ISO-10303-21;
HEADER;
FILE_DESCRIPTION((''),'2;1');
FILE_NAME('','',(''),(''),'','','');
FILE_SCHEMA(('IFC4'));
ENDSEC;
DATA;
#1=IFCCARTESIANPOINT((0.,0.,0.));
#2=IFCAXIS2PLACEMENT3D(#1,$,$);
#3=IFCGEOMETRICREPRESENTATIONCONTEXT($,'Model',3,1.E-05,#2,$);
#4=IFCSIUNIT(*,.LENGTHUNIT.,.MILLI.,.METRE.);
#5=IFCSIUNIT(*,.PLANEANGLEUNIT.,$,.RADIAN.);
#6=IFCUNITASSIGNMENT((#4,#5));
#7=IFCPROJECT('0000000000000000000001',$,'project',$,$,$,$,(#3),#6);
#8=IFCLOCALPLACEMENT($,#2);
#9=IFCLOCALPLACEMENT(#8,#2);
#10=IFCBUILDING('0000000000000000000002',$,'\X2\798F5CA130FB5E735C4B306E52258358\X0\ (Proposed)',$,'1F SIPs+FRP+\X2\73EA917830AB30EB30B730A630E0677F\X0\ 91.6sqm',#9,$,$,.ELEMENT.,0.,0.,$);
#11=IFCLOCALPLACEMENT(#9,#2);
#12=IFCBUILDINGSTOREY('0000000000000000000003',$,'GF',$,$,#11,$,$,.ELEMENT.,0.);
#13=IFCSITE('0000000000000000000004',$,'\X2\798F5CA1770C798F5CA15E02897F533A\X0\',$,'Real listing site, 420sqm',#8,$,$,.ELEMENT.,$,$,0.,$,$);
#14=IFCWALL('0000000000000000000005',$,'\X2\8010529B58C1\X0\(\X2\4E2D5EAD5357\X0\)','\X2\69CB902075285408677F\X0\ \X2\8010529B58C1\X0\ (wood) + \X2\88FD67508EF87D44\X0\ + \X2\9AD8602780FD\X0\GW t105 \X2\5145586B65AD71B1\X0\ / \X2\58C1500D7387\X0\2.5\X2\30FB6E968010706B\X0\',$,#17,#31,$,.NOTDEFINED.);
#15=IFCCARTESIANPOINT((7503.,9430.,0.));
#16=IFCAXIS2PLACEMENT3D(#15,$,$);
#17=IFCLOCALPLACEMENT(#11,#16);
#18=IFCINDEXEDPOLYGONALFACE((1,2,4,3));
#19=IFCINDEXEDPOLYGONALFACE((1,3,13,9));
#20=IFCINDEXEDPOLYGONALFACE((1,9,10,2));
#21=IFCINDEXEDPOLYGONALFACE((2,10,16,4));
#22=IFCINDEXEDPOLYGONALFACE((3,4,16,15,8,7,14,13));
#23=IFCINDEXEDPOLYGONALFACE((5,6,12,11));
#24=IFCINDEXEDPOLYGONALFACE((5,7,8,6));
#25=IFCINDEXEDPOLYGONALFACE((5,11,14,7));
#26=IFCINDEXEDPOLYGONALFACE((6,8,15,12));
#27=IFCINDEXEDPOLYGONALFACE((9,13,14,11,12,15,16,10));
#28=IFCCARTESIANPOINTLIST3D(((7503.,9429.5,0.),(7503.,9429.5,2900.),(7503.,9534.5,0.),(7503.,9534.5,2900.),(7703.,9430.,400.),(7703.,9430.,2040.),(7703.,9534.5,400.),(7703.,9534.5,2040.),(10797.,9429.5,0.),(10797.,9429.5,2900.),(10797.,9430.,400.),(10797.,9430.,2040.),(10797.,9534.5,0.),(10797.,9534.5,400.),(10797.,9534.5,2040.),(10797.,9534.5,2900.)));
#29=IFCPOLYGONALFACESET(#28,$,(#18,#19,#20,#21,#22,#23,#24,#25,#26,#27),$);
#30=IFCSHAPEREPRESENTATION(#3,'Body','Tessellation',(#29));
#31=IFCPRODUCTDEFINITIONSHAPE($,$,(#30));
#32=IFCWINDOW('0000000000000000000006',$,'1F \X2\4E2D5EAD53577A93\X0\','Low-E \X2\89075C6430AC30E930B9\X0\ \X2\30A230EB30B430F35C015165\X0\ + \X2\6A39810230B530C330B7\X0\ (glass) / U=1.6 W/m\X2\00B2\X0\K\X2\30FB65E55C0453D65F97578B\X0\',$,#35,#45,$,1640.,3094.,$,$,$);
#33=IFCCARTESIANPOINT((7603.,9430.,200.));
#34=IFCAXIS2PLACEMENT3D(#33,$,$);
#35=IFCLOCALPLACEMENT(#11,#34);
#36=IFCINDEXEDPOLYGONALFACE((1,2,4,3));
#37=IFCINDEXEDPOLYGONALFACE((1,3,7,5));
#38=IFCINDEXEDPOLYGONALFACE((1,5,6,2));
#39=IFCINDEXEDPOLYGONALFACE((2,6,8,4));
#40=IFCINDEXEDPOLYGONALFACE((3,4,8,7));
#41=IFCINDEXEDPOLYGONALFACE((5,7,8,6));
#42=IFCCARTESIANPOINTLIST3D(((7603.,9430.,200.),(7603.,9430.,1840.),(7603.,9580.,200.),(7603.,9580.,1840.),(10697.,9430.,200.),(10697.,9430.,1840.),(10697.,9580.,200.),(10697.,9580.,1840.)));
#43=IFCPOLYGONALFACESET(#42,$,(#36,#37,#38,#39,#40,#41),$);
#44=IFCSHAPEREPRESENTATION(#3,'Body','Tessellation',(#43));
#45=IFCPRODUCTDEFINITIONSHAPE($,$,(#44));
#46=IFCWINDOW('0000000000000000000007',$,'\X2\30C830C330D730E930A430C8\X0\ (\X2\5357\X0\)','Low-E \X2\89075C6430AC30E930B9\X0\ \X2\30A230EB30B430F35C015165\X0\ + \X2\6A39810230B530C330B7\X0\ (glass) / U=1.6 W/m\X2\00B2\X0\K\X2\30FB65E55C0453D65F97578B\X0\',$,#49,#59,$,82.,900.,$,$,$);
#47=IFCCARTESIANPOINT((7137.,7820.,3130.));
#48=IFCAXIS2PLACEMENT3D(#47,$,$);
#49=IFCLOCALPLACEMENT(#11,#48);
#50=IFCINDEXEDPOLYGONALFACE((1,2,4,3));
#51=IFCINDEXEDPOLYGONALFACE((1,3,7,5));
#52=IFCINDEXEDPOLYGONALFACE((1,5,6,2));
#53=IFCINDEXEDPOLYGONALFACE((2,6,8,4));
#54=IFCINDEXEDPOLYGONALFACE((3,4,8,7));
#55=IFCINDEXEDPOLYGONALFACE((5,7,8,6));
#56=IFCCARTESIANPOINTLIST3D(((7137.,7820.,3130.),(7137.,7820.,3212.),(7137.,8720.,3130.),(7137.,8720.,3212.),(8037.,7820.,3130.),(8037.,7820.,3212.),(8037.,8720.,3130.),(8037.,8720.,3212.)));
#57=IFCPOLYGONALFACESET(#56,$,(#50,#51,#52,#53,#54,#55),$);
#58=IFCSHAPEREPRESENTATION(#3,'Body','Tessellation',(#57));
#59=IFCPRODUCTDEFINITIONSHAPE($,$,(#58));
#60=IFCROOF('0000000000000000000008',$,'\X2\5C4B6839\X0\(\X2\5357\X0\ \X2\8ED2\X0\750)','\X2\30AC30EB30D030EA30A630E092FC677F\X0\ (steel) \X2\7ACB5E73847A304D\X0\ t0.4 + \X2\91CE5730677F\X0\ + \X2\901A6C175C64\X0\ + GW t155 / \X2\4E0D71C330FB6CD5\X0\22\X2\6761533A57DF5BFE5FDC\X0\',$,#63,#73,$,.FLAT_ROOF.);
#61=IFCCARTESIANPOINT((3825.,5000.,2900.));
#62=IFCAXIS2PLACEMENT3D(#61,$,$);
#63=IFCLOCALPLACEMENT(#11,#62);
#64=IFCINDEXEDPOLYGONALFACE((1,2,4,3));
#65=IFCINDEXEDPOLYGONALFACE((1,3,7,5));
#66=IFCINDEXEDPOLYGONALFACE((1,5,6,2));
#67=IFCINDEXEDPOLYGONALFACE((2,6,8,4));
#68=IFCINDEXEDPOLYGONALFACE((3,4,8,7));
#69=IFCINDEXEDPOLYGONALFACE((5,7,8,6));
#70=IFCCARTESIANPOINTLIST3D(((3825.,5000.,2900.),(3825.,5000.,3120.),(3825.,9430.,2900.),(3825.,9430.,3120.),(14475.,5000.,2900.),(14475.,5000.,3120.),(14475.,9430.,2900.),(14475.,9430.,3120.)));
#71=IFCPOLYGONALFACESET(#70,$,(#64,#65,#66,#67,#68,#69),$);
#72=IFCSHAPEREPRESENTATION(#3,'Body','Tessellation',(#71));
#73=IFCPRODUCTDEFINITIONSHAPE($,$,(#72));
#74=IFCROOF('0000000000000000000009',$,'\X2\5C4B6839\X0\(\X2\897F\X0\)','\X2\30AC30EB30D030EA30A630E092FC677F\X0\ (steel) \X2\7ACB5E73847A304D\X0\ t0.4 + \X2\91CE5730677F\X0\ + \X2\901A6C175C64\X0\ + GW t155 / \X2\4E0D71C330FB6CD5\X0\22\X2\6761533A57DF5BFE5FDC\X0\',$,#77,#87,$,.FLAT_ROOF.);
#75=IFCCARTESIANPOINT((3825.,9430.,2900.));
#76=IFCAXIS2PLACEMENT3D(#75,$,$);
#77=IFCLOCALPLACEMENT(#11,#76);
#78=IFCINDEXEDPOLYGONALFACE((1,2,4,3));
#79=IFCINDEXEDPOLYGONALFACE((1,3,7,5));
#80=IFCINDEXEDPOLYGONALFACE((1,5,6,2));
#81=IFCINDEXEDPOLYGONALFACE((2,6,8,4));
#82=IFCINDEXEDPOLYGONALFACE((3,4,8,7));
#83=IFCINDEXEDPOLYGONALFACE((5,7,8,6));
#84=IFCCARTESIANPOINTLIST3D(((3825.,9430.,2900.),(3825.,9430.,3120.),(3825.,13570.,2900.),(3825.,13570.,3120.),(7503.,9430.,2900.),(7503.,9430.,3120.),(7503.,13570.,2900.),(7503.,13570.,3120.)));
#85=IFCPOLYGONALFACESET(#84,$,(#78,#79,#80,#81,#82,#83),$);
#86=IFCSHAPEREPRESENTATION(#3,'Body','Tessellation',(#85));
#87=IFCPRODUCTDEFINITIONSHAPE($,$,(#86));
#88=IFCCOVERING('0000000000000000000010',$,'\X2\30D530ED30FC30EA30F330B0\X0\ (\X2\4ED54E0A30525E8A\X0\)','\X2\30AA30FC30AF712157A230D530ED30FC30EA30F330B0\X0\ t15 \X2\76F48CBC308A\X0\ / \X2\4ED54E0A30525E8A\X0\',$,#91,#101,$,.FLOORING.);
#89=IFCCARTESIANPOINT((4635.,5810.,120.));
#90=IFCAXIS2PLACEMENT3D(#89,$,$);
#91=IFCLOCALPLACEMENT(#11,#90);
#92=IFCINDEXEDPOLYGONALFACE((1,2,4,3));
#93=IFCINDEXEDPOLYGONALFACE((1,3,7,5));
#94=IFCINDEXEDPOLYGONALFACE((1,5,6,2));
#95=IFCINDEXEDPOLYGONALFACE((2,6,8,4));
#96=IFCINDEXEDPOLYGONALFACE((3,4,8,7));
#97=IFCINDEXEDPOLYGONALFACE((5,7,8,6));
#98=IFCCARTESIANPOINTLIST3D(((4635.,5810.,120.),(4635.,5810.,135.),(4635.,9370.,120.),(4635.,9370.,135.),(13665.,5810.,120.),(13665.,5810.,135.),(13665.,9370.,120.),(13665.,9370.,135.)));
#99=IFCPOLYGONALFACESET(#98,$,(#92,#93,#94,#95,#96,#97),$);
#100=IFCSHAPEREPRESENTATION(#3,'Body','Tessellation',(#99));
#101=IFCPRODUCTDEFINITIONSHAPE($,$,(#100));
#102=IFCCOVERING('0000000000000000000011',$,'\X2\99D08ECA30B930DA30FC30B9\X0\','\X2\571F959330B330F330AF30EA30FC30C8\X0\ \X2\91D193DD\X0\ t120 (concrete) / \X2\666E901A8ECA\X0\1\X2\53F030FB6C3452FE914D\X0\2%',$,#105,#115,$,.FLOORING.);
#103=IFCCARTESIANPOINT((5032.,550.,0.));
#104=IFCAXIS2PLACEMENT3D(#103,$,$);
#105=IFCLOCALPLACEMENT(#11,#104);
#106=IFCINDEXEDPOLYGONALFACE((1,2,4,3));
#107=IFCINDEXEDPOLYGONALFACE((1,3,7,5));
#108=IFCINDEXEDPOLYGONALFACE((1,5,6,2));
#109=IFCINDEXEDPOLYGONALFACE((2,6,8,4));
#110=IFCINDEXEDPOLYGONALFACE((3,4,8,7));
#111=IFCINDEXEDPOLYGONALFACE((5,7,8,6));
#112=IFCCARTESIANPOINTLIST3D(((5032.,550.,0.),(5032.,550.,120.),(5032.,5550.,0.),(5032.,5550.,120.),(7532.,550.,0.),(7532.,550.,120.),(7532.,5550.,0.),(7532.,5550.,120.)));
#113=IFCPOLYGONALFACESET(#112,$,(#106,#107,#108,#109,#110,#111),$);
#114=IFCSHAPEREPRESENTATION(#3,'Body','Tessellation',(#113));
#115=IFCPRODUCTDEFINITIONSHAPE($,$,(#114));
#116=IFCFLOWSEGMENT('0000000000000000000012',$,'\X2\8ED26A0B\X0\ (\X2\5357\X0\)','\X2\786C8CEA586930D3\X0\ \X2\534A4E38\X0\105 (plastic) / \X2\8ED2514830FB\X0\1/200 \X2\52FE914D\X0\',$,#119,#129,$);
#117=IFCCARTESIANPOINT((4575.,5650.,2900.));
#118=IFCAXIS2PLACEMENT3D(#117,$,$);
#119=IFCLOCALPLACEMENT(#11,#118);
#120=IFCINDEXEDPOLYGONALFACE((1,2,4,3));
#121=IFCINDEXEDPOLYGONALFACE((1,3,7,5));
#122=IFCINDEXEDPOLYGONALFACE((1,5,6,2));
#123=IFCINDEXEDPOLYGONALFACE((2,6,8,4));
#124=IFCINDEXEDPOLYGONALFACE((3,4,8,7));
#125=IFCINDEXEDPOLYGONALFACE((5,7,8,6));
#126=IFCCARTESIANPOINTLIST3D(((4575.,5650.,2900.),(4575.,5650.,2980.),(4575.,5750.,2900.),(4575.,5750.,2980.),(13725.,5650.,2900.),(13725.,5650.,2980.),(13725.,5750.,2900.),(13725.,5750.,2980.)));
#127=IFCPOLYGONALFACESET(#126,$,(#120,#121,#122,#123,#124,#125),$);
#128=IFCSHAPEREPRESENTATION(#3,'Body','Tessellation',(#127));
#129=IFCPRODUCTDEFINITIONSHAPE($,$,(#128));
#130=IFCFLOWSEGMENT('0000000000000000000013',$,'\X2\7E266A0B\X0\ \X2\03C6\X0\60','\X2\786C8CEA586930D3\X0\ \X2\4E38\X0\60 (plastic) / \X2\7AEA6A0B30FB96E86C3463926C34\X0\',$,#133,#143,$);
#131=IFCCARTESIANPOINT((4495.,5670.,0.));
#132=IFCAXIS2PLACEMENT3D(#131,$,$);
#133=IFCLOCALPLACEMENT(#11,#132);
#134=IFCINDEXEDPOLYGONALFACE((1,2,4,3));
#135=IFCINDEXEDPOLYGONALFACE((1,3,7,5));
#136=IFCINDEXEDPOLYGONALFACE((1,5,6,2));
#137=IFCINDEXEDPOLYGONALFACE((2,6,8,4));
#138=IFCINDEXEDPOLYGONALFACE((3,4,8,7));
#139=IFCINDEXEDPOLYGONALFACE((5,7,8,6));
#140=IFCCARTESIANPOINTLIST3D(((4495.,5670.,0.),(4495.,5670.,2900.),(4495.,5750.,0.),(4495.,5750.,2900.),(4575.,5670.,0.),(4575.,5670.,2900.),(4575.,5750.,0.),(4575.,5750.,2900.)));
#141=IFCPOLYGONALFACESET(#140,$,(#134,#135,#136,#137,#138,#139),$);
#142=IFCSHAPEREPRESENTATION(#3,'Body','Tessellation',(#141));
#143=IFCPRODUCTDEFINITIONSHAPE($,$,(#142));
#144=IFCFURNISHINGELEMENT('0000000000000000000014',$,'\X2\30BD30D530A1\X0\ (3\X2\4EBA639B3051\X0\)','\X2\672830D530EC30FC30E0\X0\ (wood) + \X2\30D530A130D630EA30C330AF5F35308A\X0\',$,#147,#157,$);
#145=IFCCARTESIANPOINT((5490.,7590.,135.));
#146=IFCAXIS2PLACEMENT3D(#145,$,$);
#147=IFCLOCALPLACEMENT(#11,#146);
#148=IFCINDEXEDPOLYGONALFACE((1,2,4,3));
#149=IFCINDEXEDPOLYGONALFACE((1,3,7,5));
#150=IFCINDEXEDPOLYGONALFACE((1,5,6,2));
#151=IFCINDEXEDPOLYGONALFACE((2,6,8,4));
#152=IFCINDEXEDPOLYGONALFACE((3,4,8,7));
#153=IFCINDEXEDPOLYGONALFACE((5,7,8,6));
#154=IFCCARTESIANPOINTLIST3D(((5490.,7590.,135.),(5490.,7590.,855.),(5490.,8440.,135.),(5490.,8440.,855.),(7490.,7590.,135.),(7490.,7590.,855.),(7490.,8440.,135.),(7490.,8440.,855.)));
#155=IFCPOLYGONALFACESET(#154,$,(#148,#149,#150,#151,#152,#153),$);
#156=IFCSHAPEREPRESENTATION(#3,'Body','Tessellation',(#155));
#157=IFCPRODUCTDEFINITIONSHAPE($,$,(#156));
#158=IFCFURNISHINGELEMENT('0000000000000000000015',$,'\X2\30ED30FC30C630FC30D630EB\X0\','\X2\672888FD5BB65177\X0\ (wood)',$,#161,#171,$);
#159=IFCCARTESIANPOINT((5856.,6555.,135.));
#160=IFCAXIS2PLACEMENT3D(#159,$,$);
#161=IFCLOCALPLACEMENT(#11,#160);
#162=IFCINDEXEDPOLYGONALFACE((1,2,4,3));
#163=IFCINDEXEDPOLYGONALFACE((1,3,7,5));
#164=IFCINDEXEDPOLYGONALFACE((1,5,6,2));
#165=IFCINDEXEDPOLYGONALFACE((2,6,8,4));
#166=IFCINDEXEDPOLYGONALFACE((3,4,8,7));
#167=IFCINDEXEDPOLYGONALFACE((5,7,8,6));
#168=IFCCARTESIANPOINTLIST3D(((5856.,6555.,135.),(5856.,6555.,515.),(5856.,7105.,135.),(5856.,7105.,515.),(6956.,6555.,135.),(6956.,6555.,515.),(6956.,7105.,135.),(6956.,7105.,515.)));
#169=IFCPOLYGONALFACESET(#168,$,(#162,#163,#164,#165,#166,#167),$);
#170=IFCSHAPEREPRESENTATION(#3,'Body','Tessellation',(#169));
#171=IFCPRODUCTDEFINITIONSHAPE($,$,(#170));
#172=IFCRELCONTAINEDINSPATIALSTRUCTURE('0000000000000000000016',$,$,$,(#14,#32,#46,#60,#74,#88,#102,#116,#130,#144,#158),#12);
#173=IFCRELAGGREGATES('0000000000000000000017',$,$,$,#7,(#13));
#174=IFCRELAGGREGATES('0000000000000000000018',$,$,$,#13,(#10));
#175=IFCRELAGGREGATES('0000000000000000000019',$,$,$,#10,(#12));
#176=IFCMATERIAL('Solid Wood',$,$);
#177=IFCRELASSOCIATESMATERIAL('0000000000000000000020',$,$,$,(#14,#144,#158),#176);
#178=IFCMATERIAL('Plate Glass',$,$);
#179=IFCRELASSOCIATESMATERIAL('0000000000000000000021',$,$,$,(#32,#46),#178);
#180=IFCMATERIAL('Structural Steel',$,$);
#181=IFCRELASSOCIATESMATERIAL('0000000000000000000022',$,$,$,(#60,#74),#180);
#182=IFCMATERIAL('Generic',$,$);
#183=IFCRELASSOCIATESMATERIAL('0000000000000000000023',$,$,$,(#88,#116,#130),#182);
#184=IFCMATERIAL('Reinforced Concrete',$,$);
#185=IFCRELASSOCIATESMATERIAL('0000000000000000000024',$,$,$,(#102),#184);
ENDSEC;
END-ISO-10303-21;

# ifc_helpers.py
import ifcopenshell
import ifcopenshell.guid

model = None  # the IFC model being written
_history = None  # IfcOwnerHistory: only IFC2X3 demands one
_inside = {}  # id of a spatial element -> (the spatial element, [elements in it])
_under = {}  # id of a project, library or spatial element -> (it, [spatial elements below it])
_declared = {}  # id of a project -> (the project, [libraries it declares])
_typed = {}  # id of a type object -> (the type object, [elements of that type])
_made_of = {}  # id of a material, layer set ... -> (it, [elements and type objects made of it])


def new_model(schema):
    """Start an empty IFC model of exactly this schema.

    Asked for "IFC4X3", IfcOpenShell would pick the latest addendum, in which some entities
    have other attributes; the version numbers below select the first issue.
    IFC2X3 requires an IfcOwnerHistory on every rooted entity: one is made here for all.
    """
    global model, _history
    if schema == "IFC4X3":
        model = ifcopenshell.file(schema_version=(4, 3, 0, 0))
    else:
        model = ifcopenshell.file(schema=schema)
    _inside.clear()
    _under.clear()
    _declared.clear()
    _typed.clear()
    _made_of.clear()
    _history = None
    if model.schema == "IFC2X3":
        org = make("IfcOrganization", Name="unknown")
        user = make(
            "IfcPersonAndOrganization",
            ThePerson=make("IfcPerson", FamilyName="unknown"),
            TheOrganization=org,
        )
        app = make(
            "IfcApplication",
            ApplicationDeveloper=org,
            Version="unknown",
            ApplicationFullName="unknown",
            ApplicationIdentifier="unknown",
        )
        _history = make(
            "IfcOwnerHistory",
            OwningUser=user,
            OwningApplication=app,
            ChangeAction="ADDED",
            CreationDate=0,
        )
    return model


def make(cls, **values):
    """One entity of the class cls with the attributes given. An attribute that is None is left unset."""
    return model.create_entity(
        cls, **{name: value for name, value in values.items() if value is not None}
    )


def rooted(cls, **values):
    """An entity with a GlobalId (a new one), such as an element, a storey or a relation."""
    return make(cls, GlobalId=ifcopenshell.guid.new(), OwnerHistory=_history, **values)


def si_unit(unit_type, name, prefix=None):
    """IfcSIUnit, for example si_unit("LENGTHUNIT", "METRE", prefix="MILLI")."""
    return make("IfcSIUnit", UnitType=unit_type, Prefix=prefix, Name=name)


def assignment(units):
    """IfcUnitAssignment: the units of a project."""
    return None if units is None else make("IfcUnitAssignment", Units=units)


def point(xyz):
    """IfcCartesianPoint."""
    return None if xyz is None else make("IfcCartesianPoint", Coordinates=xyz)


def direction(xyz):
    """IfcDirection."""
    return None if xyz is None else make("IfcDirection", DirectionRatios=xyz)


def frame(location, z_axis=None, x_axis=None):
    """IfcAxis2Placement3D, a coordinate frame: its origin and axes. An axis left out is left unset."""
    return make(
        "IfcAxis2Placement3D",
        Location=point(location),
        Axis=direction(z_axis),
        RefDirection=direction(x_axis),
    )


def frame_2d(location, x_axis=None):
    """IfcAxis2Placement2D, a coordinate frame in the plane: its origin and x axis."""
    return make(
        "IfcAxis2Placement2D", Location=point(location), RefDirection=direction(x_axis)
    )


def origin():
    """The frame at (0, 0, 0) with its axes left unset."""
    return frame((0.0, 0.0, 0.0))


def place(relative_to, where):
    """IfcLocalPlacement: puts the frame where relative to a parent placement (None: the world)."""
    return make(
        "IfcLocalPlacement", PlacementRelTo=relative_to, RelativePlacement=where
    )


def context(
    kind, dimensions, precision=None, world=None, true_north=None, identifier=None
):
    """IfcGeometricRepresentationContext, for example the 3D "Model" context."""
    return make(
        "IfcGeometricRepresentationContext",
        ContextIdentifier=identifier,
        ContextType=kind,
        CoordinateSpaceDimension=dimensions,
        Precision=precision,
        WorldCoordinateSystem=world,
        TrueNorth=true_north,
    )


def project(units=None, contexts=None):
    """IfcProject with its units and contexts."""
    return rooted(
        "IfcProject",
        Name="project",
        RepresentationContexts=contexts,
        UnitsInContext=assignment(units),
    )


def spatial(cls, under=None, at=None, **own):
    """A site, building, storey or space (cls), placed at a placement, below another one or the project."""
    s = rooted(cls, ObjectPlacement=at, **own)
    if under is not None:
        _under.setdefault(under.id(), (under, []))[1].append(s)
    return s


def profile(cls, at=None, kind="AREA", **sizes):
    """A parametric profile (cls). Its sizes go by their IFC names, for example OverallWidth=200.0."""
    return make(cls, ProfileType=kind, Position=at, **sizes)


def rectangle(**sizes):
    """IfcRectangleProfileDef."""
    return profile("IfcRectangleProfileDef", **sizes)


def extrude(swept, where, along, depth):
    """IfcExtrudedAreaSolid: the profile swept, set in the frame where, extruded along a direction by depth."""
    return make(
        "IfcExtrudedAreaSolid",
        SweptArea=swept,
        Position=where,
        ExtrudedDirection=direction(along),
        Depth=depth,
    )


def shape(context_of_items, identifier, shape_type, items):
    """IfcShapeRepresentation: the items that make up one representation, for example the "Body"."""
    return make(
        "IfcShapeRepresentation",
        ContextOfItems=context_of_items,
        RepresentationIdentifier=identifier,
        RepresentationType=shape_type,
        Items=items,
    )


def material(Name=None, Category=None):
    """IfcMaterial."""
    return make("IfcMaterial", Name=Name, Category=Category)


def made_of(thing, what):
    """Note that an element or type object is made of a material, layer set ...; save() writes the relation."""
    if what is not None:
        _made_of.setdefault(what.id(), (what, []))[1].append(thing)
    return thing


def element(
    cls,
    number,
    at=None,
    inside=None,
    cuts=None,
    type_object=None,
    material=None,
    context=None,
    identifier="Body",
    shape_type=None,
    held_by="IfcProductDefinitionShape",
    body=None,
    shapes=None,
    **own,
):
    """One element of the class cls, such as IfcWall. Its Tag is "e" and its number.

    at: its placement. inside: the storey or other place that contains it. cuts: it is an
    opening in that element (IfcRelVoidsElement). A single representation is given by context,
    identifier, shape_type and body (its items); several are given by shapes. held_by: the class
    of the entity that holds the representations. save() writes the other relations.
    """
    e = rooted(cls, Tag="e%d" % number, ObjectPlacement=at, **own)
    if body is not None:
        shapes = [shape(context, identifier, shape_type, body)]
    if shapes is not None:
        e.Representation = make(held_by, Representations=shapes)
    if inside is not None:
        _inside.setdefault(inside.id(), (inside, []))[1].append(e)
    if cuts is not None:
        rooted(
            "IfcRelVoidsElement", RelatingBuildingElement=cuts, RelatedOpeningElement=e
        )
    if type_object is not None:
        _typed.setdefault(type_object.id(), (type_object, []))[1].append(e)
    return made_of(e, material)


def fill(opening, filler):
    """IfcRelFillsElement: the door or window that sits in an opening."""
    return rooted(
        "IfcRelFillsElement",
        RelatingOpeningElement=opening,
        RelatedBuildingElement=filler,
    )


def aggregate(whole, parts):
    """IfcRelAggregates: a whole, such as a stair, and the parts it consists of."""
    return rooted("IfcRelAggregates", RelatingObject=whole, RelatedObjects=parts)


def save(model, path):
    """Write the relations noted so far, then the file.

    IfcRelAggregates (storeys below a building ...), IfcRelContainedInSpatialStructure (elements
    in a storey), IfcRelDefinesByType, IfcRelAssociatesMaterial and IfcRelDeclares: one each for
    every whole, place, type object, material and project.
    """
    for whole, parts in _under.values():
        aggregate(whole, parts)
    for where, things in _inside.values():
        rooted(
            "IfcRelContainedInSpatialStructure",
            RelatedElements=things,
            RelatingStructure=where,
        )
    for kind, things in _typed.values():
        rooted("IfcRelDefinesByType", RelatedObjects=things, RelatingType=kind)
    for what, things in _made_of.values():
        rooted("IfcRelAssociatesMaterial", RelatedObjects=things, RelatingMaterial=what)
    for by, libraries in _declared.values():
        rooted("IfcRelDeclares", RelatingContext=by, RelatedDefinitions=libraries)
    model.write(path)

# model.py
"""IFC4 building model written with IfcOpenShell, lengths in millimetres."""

from ifc_helpers import new_model, si_unit, frame, frame_2d, origin, place, context, project, spatial, rectangle, extrude, material, element, fill, save


model = new_model("IFC4")

# Units and contexts
model_context = context("Model", 3, precision=1e-05, world=origin())
ifc_project = project(units=[si_unit("LENGTHUNIT", "METRE", prefix="MILLI"), si_unit("PLANEANGLEUNIT", "RADIAN")], contexts=[model_context])

# Site, building, storey
site_placement = place(None, origin())
site = spatial("IfcSite", under=ifc_project, at=site_placement, Name="福岡県福岡市西区", ObjectType="Real listing site, 420sqm", CompositionType="ELEMENT", RefElevation=0.0)
building_placement = place(site_placement, origin())
building = spatial("IfcBuilding", under=site, at=building_placement, Name="福岡・平屋の別荘 (Proposed)", ObjectType="1F SIPs+FRP+珪酸カルシウム板 91.6sqm", CompositionType="ELEMENT", ElevationOfRefHeight=0.0, ElevationOfTerrain=0.0)
storey_placement = place(building_placement, origin())
storey = spatial("IfcBuildingStorey", under=building, at=storey_placement, Name="GF", CompositionType="ELEMENT", Elevation=0.0)

# Shared definitions
ifc_material_1 = material(Name="Solid Wood")

# Shared definitions
ifc_material_2 = material(Name="Reinforced Concrete")

# Shared definitions
ifc_material_3 = material(Name="Plate Glass")

# Wall, opening, window
wall_1_placement = place(storey_placement, frame((7503.0, 9430.0, 0.0)))
wall_1 = element("IfcWall", 1, at=wall_1_placement, inside=storey, material=ifc_material_1, Name="耐力壁(中庭南)", Description="構造用合板 耐力壁 (wood) + 製材軸組 + 高性能GW t105 充填断熱 / 壁倍率2.5・準耐火", PredefinedType="NOTDEFINED", context=model_context, shape_type="SweptSolid", body=[
    extrude(rectangle(XDim=3294.0, YDim=105.0, at=frame_2d((1647.0, 52.0))), frame((7503.0, 9430.0, 0.0)), (0.0, 0.0, 1.0), 2900.0),
])
opening_1_placement = place(storey_placement, frame((7603.0, 9430.0, 200.0)))
opening_1 = element("IfcOpeningElement", 2, at=opening_1_placement, cuts=wall_1, PredefinedType="NOTDEFINED", context=model_context, shape_type="SweptSolid", body=[
    extrude(rectangle(XDim=3094.0, YDim=150.0, at=frame_2d((1547.0, 75.0))), frame((7603.0, 9430.0, 200.0)), (0.0, 0.0, 1.0), 1640.0),
])
window_1_placement = place(storey_placement, frame((7603.0, 9430.0, 200.0)))
window_1 = element("IfcWindow", 3, at=window_1_placement, inside=storey, material=ifc_material_3, Name="1F 中庭南窓", Description="Low-E 複層ガラス アルゴン封入 + 樹脂サッシ (glass) / U=1.6 W/m²K・日射取得型", OverallHeight=1640.0, OverallWidth=3094.0, context=model_context, shape_type="SweptSolid", body=[
    extrude(rectangle(XDim=3094.0, YDim=150.0, at=frame_2d((1547.0, 75.0))), frame((7603.0, 9430.0, 200.0)), (0.0, 0.0, 1.0), 1640.0),
])
fill(opening_1, window_1)

# Window
window_2_placement = place(storey_placement, frame((7137.0, 7820.0, 3130.0)))
element("IfcWindow", 4, at=window_2_placement, inside=storey, material=ifc_material_3, Name="トップライト (南)", Description="Low-E 複層ガラス アルゴン封入 + 樹脂サッシ (glass) / U=1.6 W/m²K・日射取得型", OverallHeight=82.0, OverallWidth=900.0, context=model_context, shape_type="SweptSolid", body=[
    extrude(rectangle(XDim=900.0, YDim=900.0, at=frame_2d((450.0, 450.0))), frame((7137.0, 7820.0, 3130.0)), (0.0, 0.0, 1.0), 82.0),
])

# Roofs
ifc_material_4 = material(Name="Structural Steel")
roof_1_placement = place(storey_placement, frame((3825.0, 5000.0, 2900.0)))
element("IfcRoof", 5, at=roof_1_placement, inside=storey, material=ifc_material_4, Name="屋根(南 軒750)", Description="ガルバリウム鋼板 (steel) 立平葺き t0.4 + 野地板 + 通気層 + GW t155 / 不燃・法22条区域対応", PredefinedType="FLAT_ROOF", context=model_context, shape_type="SweptSolid", body=[
    extrude(rectangle(XDim=10650.0, YDim=4430.0, at=frame_2d((5325.0, 2215.0))), frame((3825.0, 5000.0, 2900.0)), (0.0, 0.0, 1.0), 220.0),
])
roof_2_placement = place(storey_placement, frame((3825.0, 9430.0, 2900.0)))
element("IfcRoof", 6, at=roof_2_placement, inside=storey, material=ifc_material_4, Name="屋根(西)", Description="ガルバリウム鋼板 (steel) 立平葺き t0.4 + 野地板 + 通気層 + GW t155 / 不燃・法22条区域対応", PredefinedType="FLAT_ROOF", context=model_context, shape_type="SweptSolid", body=[
    extrude(rectangle(XDim=3678.0, YDim=4140.0, at=frame_2d((1839.0, 2070.0))), frame((3825.0, 9430.0, 2900.0)), (0.0, 0.0, 1.0), 220.0),
])

# Coverings
ifc_material_5 = material(Name="Generic")
covering_1_placement = place(storey_placement, frame((4635.0, 5810.0, 120.0)))
element("IfcCovering", 7, at=covering_1_placement, inside=storey, material=ifc_material_5, Name="フローリング (仕上げ床)", Description="オーク無垢フローリング t15 直貼り / 仕上げ床", PredefinedType="FLOORING", context=model_context, shape_type="SweptSolid", body=[
    extrude(rectangle(XDim=9030.0, YDim=3560.0, at=frame_2d((4515.0, 1780.0))), frame((4635.0, 5810.0, 120.0)), (0.0, 0.0, 1.0), 15.0),
])
covering_2_placement = place(storey_placement, frame((5032.0, 550.0, 0.0)))
element("IfcCovering", 8, at=covering_2_placement, inside=storey, material=ifc_material_2, Name="駐車スペース", Description="土間コンクリート 金鏝 t120 (concrete) / 普通車1台・水勾配2%", PredefinedType="FLOORING", context=model_context, shape_type="SweptSolid", body=[
    extrude(rectangle(XDim=2500.0, YDim=5000.0, at=frame_2d((1250.0, 2500.0))), frame((5032.0, 550.0, 0.0)), (0.0, 0.0, 1.0), 120.0),
])

# Flow segments
flow_segment_1_placement = place(storey_placement, frame((4575.0, 5650.0, 2900.0)))
element("IfcFlowSegment", 9, at=flow_segment_1_placement, inside=storey, material=ifc_material_5, Name="軒樋 (南)", Description="硬質塩ビ 半丸105 (plastic) / 軒先・1/200 勾配", context=model_context, shape_type="SweptSolid", body=[
    extrude(rectangle(XDim=9150.0, YDim=100.0, at=frame_2d((4575.0, 50.0))), frame((4575.0, 5650.0, 2900.0)), (0.0, 0.0, 1.0), 80.0),
])
flow_segment_2_placement = place(storey_placement, frame((4495.0, 5670.0, 0.0)))
element("IfcFlowSegment", 10, at=flow_segment_2_placement, inside=storey, material=ifc_material_5, Name="縦樋 φ60", Description="硬質塩ビ 丸60 (plastic) / 竪樋・雨水排水", context=model_context, shape_type="SweptSolid", body=[
    extrude(rectangle(XDim=80.0, YDim=80.0, at=frame_2d((40.0, 40.0))), frame((4495.0, 5670.0, 0.0)), (0.0, 0.0, 1.0), 2900.0),
])

# Furnishing elements
furnishing_1_placement = place(storey_placement, frame((5490.0, 7590.0, 135.0)))
element("IfcFurnishingElement", 11, at=furnishing_1_placement, inside=storey, material=ifc_material_1, Name="ソファ (3人掛け)", Description="木フレーム (wood) + ファブリック張り", context=model_context, shape_type="SweptSolid", body=[
    extrude(rectangle(XDim=2000.0, YDim=850.0, at=frame_2d((1000.0, 425.0))), frame((5490.0, 7590.0, 135.0)), (0.0, 0.0, 1.0), 720.0),
])
furnishing_2_placement = place(storey_placement, frame((5856.0, 6555.0, 135.0)))
element("IfcFurnishingElement", 12, at=furnishing_2_placement, inside=storey, material=ifc_material_1, Name="ローテーブル", Description="木製家具 (wood)", context=model_context, shape_type="SweptSolid", body=[
    extrude(rectangle(XDim=1100.0, YDim=550.0, at=frame_2d((550.0, 275.0))), frame((5856.0, 6555.0, 135.0)), (0.0, 0.0, 1.0), 380.0),
])

save(model, "model.ifc")
